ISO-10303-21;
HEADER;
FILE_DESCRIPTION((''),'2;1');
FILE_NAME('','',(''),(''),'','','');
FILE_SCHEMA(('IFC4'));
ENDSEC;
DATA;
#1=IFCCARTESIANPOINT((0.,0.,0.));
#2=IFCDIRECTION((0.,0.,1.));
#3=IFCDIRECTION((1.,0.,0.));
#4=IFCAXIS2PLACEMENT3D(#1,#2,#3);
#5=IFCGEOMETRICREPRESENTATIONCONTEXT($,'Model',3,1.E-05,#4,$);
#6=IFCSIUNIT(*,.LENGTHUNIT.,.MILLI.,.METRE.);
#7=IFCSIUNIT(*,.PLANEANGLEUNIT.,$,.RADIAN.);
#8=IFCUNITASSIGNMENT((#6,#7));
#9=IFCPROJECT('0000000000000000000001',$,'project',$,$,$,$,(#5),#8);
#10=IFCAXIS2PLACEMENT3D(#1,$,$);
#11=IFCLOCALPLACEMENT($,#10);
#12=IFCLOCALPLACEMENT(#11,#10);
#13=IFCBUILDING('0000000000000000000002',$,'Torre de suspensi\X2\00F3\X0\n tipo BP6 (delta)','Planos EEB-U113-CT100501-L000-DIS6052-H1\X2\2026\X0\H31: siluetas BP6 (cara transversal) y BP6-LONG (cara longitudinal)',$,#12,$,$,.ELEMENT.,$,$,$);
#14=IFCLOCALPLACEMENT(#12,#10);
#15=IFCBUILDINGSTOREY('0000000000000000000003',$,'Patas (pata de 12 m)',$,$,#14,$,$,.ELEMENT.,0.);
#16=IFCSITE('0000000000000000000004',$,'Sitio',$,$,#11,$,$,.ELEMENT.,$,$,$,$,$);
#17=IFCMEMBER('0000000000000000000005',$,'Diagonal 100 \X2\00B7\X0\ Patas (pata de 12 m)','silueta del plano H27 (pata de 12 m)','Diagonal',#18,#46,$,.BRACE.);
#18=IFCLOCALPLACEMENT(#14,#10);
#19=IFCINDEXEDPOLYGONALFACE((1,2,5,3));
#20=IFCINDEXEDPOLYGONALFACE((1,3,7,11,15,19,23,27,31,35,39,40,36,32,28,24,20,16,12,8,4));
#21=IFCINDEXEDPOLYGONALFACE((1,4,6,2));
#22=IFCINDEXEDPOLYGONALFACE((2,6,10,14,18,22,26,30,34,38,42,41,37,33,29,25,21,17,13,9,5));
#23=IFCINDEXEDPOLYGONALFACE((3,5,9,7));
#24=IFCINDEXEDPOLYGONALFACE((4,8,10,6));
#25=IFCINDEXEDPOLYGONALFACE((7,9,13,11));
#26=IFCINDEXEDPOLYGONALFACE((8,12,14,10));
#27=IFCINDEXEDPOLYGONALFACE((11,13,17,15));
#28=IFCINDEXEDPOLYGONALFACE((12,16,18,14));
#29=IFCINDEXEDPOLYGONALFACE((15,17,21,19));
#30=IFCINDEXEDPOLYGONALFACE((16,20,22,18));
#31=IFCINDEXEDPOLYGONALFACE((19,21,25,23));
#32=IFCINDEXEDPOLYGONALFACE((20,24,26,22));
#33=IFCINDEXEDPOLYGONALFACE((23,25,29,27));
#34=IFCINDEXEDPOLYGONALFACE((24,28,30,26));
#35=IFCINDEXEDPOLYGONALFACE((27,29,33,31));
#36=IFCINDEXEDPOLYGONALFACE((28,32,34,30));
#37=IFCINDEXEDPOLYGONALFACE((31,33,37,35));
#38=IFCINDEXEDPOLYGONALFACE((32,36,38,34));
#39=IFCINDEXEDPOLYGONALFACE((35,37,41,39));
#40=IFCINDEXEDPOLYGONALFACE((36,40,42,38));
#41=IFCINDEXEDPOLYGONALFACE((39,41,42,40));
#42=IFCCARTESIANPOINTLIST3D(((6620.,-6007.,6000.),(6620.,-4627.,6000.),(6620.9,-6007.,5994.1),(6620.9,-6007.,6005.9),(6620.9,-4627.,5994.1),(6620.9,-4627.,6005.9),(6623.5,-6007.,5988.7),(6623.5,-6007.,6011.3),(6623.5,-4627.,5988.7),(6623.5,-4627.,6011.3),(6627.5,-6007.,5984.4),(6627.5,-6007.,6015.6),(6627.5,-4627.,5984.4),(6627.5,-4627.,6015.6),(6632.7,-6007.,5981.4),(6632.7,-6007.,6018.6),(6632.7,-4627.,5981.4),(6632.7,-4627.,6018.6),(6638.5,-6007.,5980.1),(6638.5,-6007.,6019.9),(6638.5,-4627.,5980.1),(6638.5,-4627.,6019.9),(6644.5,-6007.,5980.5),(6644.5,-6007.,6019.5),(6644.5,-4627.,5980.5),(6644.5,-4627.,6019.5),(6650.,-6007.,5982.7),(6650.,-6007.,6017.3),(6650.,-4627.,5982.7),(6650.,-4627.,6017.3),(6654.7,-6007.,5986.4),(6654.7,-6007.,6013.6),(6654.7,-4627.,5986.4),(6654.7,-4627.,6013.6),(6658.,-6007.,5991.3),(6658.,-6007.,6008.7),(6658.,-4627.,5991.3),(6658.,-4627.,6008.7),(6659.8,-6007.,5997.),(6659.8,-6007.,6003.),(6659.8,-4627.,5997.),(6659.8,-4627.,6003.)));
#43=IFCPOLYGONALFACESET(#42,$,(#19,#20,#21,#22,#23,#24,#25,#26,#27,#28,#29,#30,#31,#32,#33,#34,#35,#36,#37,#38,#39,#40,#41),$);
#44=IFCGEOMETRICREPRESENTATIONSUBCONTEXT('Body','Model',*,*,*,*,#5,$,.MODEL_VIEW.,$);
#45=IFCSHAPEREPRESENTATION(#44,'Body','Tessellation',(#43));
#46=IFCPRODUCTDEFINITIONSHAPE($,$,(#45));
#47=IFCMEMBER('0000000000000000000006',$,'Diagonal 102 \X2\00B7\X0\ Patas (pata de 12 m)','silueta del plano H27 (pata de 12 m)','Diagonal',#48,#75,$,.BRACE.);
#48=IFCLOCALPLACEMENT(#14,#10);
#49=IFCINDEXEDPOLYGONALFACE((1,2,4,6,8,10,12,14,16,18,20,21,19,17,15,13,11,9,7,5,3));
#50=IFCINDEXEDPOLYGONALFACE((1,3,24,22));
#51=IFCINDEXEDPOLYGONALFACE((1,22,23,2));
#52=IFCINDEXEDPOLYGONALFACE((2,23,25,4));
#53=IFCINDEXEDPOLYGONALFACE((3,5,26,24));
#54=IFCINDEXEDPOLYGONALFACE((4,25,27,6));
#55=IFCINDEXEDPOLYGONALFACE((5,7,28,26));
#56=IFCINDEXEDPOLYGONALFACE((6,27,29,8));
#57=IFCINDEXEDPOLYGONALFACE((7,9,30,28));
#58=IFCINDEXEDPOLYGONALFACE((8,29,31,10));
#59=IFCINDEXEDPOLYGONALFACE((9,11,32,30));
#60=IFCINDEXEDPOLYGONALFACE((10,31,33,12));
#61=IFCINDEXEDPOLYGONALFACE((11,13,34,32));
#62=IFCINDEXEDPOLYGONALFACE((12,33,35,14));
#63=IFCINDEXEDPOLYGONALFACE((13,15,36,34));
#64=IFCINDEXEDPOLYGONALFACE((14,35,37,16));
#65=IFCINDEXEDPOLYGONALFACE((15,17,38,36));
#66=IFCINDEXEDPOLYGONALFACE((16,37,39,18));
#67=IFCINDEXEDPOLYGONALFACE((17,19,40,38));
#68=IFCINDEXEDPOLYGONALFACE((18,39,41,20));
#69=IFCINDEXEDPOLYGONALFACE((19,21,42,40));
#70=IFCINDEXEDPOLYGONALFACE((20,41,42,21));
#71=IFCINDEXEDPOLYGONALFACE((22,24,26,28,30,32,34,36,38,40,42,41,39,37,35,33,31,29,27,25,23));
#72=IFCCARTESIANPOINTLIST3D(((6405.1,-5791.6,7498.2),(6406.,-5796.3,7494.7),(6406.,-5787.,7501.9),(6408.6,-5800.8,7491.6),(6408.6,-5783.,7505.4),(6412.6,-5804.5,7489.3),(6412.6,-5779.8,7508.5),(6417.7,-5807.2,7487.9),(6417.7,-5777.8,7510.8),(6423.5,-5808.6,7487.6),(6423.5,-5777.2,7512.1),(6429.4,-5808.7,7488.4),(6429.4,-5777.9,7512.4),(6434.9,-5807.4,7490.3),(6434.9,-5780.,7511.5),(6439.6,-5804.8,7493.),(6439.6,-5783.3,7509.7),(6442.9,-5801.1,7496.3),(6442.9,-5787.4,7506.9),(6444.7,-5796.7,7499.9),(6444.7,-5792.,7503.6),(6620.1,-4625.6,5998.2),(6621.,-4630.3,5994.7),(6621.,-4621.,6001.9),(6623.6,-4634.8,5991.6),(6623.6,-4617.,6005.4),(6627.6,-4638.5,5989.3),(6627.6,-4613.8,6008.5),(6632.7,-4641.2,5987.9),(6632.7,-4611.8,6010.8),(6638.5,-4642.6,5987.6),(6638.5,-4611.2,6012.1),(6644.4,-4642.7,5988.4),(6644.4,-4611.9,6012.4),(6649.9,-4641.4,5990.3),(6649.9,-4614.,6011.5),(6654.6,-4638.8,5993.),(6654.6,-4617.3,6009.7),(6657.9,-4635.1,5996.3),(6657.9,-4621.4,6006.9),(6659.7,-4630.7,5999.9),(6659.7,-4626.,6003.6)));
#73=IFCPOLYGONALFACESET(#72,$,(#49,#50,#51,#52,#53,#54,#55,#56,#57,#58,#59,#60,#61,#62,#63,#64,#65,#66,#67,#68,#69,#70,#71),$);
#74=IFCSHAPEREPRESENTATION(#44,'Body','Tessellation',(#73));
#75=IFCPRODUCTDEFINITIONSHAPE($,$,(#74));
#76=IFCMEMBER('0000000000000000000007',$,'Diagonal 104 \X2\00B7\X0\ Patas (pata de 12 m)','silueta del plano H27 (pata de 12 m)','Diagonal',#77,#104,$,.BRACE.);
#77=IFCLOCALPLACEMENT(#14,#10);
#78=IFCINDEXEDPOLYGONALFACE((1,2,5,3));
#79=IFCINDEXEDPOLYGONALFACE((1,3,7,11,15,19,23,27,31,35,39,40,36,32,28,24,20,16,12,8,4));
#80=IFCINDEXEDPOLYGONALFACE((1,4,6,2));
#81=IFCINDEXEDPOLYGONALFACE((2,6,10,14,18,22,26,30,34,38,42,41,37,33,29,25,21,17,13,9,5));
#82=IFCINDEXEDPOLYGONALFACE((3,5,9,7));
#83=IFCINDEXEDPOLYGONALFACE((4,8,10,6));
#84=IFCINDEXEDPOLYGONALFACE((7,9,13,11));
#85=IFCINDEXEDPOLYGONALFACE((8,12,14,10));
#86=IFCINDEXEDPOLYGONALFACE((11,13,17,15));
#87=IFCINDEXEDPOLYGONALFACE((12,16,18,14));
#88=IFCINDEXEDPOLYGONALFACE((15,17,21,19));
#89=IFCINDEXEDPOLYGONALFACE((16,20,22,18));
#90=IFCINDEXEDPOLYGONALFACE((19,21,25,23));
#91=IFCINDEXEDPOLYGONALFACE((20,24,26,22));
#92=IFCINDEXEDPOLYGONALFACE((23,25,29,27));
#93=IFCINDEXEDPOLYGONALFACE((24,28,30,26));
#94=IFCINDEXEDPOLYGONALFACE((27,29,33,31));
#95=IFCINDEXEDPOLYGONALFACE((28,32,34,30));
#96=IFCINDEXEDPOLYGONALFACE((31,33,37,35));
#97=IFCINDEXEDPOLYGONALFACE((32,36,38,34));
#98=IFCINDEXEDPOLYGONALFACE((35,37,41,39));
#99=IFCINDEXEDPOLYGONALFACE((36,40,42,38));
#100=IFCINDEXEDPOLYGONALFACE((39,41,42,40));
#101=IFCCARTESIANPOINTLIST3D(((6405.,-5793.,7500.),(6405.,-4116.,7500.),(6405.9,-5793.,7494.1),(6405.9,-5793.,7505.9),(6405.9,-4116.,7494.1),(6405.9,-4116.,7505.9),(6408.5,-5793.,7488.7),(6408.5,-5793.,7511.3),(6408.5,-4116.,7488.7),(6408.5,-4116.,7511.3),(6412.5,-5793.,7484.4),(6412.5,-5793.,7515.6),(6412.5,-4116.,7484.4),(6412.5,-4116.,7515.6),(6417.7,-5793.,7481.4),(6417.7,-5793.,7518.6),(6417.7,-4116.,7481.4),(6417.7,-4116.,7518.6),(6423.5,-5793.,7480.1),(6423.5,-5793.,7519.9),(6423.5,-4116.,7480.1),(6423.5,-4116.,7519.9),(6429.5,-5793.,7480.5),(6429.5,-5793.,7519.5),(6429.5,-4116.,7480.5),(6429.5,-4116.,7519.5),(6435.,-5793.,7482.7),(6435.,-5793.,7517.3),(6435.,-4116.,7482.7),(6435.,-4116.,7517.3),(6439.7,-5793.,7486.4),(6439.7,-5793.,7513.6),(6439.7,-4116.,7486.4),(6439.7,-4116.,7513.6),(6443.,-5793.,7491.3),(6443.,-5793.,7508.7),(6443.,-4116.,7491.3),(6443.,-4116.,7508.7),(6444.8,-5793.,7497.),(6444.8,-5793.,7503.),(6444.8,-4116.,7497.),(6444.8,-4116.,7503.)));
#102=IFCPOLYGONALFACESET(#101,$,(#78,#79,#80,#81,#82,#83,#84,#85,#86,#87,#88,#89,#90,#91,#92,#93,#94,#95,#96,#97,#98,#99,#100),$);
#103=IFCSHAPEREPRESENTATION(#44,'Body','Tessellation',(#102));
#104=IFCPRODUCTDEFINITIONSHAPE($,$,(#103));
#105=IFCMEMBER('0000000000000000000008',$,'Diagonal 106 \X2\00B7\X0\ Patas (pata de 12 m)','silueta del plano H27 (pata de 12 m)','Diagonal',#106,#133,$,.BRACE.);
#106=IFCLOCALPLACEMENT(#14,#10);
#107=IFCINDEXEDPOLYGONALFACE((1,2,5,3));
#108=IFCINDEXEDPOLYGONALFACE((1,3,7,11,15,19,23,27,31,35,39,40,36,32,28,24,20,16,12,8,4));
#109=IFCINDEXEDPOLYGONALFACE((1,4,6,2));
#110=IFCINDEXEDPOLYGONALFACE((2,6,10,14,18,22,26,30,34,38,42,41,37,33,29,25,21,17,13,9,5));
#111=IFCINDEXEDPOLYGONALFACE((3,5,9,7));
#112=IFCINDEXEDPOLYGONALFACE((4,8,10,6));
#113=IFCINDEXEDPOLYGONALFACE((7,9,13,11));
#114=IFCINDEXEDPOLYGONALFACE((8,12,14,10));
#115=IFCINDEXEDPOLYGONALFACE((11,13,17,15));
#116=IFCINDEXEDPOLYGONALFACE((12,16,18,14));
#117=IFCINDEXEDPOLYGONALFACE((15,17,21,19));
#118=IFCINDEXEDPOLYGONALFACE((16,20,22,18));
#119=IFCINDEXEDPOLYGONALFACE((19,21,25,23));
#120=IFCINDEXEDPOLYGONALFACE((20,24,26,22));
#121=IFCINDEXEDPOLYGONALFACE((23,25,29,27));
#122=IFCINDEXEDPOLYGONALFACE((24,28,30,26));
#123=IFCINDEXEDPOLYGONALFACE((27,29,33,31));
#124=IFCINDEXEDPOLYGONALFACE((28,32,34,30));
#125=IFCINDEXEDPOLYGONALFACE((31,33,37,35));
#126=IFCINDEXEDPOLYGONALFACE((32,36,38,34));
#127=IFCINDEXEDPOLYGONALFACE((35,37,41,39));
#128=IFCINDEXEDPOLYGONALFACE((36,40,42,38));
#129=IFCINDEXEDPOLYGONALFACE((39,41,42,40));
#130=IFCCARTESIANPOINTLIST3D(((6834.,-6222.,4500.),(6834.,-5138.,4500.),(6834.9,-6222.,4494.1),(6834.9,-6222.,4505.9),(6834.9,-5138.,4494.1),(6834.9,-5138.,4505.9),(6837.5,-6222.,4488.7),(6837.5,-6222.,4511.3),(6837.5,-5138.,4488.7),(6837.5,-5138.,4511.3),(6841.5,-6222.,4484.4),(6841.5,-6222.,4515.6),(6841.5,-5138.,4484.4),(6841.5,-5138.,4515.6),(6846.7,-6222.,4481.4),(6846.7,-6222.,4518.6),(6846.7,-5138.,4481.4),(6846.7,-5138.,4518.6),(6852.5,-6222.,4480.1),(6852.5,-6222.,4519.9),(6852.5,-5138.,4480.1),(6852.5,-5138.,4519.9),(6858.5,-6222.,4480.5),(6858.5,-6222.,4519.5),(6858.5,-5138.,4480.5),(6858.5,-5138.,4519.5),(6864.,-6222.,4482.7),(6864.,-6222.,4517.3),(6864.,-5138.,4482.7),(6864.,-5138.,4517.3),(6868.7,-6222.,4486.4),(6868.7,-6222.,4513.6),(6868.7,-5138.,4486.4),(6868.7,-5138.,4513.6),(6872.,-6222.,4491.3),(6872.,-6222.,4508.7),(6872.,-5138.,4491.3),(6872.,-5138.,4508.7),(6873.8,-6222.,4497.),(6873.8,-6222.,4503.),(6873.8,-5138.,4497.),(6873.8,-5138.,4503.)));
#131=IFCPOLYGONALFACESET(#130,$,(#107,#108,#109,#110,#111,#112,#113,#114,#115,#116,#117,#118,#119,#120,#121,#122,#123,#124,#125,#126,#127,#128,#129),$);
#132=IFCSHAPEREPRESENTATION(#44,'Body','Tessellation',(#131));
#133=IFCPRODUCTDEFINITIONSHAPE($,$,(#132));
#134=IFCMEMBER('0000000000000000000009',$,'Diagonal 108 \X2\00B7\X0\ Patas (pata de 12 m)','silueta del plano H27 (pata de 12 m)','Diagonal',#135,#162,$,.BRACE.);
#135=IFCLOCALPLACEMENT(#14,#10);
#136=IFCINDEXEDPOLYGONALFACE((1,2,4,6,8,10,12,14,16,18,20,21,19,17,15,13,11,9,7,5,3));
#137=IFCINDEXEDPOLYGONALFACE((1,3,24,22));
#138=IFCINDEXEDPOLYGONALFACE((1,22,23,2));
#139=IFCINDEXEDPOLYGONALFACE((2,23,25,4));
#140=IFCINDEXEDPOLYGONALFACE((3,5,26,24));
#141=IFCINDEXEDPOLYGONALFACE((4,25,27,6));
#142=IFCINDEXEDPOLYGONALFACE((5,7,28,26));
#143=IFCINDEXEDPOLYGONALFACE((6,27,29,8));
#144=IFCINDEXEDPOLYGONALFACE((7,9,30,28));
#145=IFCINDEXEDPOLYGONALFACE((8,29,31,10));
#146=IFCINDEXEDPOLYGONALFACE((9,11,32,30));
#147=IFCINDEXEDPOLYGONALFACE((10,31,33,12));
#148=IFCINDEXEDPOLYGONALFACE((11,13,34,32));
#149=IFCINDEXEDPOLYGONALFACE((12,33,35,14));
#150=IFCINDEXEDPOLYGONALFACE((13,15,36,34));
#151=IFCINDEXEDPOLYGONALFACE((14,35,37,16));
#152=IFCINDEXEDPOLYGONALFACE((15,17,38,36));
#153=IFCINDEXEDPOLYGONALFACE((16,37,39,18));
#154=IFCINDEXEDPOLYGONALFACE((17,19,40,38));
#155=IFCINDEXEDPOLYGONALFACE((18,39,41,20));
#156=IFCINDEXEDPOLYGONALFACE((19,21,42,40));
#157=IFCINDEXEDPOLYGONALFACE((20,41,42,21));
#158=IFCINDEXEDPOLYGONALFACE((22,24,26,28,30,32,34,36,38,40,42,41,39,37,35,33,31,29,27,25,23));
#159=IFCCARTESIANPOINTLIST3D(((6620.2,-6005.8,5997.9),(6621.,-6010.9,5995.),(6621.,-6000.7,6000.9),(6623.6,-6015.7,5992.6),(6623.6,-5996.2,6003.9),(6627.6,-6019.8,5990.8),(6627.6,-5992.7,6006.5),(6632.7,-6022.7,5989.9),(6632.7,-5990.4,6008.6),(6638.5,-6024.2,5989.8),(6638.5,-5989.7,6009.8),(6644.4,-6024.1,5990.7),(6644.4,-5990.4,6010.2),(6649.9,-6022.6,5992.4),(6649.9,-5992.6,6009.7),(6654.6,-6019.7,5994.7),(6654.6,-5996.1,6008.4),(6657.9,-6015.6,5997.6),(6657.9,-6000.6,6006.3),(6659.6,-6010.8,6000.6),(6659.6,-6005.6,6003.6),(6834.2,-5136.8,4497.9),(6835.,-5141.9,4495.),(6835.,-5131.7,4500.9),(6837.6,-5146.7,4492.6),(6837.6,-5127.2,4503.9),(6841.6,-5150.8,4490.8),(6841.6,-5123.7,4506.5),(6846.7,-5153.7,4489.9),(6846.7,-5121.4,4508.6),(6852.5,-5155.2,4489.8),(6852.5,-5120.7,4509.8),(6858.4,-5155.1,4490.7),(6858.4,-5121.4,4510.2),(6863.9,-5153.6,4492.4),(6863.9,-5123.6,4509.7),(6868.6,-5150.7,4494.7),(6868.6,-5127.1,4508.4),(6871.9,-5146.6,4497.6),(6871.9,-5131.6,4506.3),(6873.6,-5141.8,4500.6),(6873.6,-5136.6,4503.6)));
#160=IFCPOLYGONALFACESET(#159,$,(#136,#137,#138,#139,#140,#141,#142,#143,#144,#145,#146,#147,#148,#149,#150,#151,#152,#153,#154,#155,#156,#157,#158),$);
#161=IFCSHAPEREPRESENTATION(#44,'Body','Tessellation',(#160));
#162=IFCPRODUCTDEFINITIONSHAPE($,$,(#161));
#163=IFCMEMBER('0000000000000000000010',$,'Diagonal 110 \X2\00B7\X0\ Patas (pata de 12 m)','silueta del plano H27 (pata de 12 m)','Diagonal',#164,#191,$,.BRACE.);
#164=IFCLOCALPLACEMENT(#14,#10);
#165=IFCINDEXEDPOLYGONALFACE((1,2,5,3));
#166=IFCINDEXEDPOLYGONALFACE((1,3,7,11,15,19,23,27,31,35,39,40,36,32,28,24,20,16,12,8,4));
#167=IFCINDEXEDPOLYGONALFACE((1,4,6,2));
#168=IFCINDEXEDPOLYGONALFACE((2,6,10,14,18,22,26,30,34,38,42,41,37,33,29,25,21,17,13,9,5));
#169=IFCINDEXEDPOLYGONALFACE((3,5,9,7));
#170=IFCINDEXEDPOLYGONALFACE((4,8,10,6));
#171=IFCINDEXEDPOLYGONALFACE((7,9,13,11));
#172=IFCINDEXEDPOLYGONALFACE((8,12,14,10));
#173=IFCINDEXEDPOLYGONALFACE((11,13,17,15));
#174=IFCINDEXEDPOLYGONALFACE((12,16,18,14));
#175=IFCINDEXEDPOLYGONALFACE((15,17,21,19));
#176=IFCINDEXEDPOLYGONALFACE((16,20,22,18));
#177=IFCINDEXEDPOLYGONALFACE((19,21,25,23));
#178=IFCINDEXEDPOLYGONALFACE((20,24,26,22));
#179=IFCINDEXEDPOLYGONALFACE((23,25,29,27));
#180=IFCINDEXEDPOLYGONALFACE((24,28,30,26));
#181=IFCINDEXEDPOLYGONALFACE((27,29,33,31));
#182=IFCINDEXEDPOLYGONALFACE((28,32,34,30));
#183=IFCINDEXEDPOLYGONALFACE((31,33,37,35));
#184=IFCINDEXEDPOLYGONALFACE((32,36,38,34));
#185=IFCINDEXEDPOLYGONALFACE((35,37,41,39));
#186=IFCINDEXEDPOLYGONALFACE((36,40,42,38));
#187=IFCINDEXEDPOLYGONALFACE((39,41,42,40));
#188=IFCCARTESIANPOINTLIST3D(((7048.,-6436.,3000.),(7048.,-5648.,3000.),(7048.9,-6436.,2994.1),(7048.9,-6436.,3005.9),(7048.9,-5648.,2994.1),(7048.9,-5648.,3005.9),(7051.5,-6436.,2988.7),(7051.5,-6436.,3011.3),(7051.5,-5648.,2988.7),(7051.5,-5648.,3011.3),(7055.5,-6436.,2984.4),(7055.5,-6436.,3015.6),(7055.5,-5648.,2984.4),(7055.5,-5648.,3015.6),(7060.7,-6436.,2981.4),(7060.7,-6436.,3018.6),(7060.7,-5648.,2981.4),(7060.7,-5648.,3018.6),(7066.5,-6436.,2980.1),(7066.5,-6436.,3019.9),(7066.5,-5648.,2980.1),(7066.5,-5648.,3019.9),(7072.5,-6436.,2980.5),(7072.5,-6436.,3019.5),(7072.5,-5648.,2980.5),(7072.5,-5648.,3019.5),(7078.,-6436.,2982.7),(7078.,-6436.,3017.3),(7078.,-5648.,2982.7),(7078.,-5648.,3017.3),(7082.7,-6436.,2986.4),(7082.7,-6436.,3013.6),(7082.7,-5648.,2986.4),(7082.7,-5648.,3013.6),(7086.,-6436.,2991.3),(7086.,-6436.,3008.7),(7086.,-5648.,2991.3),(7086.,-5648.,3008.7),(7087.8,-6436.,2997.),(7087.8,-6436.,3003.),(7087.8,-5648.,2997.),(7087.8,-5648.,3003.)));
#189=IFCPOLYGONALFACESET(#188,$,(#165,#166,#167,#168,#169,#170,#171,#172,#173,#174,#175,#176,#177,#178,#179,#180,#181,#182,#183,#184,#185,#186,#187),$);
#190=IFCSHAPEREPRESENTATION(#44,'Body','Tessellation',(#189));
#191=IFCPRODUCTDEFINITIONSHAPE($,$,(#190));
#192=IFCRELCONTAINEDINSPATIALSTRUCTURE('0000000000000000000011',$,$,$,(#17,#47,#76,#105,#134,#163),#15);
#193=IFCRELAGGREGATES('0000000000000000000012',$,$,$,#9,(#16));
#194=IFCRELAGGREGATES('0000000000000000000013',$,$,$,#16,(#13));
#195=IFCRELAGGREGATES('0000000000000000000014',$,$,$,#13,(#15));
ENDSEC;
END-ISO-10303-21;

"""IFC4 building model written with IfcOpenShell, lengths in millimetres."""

from ifc_helpers import new_model, si_unit, frame, origin, origin_with_axes, place, context, subcontext, project, spatial, circle, extrude, element, save


model = new_model("IFC4")

# Units and contexts
model_context = context("Model", 3, precision=1e-05, world=origin_with_axes())
body_context = subcontext(model_context, "Body", "Model", "MODEL_VIEW")
ifc_project = project(units=[si_unit("LENGTHUNIT", "METRE", prefix="MILLI"), si_unit("PLANEANGLEUNIT", "RADIAN")], contexts=[model_context])

# Site, building, storey
site_placement = place(None, origin())
site = spatial("IfcSite", under=ifc_project, at=site_placement, Name="Sitio", CompositionType="ELEMENT")
building_placement = place(site_placement, origin())
building = spatial("IfcBuilding", under=site, at=building_placement, Name="Torre de suspensión tipo BP6 (delta)", Description="Planos EEB-U113-CT100501-L000-DIS6052-H1…H31: siluetas BP6 (cara transversal) y BP6-LONG (cara longitudinal)", CompositionType="ELEMENT")
storey_placement = place(building_placement, origin())
storey = spatial("IfcBuildingStorey", under=building, at=storey_placement, Name="Patas (pata de 12 m)", CompositionType="ELEMENT", Elevation=0.0)

# Members
member_1_placement = place(storey_placement, frame((6640.0, -6007.0, 6000.0), z_axis=(0.0, 1.0, 0.0), x_axis=(-1.0, 0.0, 0.0)))
element("IfcMember", 1, at=member_1_placement, inside=storey, Name="Diagonal 100 · Patas (pata de 12 m)", Description="silueta del plano H27 (pata de 12 m)", ObjectType="Diagonal", PredefinedType="BRACE", context=body_context, shape_type="SweptSolid", body=[
    extrude(circle(Radius=20.0), None, (0.0, 0.0, 1.0), 1380.0),
])
member_2_placement = place(storey_placement, frame((6640.0, -4627.0, 6000.0), z_axis=(-0.112447, -0.60983, 0.784515), x_axis=(-0.993658, 0.069011, -0.08878)))
element("IfcMember", 2, at=member_2_placement, inside=storey, Name="Diagonal 102 · Patas (pata de 12 m)", Description="silueta del plano H27 (pata de 12 m)", ObjectType="Diagonal", PredefinedType="BRACE", context=body_context, shape_type="SweptSolid", body=[
    extrude(circle(Radius=20.0), None, (0.0, 0.0, 1.0), 1912.0),
])
member_3_placement = place(storey_placement, frame((6425.0, -5793.0, 7500.0), z_axis=(0.0, 1.0, 0.0), x_axis=(-1.0, 0.0, 0.0)))
element("IfcMember", 3, at=member_3_placement, inside=storey, Name="Diagonal 104 · Patas (pata de 12 m)", Description="silueta del plano H27 (pata de 12 m)", ObjectType="Diagonal", PredefinedType="BRACE", context=body_context, shape_type="SweptSolid", body=[
    extrude(circle(Radius=20.0), None, (0.0, 0.0, 1.0), 1677.0),
])
member_4_placement = place(storey_placement, frame((6854.0, -6222.0, 4500.0), z_axis=(0.0, 1.0, 0.0), x_axis=(-1.0, 0.0, 0.0)))
element("IfcMember", 4, at=member_4_placement, inside=storey, Name="Diagonal 106 · Patas (pata de 12 m)", Description="silueta del plano H27 (pata de 12 m)", ObjectType="Diagonal", PredefinedType="BRACE", context=body_context, shape_type="SweptSolid", body=[
    extrude(circle(Radius=20.0), None, (0.0, 0.0, 1.0), 1084.0),
])
member_5_placement = place(storey_placement, frame((6854.0, -5138.0, 4500.0), z_axis=(-0.122517, -0.49751, 0.858763), x_axis=(-0.992466, 0.061416, -0.106012)))
element("IfcMember", 5, at=member_5_placement, inside=storey, Name="Diagonal 108 · Patas (pata de 12 m)", Description="silueta del plano H27 (pata de 12 m)", ObjectType="Diagonal", PredefinedType="BRACE", context=body_context, shape_type="SweptSolid", body=[
    extrude(circle(Radius=20.0), None, (0.0, 0.0, 1.0), 1746.7),
])
member_6_placement = place(storey_placement, frame((7068.0, -6436.0, 3000.0), z_axis=(0.0, 1.0, 0.0), x_axis=(-1.0, 0.0, 0.0)))
element("IfcMember", 6, at=member_6_placement, inside=storey, Name="Diagonal 110 · Patas (pata de 12 m)", Description="silueta del plano H27 (pata de 12 m)", ObjectType="Diagonal", PredefinedType="BRACE", context=body_context, shape_type="SweptSolid", body=[
    extrude(circle(Radius=20.0), None, (0.0, 0.0, 1.0), 788.0),
])

save(model, "model.ifc")
